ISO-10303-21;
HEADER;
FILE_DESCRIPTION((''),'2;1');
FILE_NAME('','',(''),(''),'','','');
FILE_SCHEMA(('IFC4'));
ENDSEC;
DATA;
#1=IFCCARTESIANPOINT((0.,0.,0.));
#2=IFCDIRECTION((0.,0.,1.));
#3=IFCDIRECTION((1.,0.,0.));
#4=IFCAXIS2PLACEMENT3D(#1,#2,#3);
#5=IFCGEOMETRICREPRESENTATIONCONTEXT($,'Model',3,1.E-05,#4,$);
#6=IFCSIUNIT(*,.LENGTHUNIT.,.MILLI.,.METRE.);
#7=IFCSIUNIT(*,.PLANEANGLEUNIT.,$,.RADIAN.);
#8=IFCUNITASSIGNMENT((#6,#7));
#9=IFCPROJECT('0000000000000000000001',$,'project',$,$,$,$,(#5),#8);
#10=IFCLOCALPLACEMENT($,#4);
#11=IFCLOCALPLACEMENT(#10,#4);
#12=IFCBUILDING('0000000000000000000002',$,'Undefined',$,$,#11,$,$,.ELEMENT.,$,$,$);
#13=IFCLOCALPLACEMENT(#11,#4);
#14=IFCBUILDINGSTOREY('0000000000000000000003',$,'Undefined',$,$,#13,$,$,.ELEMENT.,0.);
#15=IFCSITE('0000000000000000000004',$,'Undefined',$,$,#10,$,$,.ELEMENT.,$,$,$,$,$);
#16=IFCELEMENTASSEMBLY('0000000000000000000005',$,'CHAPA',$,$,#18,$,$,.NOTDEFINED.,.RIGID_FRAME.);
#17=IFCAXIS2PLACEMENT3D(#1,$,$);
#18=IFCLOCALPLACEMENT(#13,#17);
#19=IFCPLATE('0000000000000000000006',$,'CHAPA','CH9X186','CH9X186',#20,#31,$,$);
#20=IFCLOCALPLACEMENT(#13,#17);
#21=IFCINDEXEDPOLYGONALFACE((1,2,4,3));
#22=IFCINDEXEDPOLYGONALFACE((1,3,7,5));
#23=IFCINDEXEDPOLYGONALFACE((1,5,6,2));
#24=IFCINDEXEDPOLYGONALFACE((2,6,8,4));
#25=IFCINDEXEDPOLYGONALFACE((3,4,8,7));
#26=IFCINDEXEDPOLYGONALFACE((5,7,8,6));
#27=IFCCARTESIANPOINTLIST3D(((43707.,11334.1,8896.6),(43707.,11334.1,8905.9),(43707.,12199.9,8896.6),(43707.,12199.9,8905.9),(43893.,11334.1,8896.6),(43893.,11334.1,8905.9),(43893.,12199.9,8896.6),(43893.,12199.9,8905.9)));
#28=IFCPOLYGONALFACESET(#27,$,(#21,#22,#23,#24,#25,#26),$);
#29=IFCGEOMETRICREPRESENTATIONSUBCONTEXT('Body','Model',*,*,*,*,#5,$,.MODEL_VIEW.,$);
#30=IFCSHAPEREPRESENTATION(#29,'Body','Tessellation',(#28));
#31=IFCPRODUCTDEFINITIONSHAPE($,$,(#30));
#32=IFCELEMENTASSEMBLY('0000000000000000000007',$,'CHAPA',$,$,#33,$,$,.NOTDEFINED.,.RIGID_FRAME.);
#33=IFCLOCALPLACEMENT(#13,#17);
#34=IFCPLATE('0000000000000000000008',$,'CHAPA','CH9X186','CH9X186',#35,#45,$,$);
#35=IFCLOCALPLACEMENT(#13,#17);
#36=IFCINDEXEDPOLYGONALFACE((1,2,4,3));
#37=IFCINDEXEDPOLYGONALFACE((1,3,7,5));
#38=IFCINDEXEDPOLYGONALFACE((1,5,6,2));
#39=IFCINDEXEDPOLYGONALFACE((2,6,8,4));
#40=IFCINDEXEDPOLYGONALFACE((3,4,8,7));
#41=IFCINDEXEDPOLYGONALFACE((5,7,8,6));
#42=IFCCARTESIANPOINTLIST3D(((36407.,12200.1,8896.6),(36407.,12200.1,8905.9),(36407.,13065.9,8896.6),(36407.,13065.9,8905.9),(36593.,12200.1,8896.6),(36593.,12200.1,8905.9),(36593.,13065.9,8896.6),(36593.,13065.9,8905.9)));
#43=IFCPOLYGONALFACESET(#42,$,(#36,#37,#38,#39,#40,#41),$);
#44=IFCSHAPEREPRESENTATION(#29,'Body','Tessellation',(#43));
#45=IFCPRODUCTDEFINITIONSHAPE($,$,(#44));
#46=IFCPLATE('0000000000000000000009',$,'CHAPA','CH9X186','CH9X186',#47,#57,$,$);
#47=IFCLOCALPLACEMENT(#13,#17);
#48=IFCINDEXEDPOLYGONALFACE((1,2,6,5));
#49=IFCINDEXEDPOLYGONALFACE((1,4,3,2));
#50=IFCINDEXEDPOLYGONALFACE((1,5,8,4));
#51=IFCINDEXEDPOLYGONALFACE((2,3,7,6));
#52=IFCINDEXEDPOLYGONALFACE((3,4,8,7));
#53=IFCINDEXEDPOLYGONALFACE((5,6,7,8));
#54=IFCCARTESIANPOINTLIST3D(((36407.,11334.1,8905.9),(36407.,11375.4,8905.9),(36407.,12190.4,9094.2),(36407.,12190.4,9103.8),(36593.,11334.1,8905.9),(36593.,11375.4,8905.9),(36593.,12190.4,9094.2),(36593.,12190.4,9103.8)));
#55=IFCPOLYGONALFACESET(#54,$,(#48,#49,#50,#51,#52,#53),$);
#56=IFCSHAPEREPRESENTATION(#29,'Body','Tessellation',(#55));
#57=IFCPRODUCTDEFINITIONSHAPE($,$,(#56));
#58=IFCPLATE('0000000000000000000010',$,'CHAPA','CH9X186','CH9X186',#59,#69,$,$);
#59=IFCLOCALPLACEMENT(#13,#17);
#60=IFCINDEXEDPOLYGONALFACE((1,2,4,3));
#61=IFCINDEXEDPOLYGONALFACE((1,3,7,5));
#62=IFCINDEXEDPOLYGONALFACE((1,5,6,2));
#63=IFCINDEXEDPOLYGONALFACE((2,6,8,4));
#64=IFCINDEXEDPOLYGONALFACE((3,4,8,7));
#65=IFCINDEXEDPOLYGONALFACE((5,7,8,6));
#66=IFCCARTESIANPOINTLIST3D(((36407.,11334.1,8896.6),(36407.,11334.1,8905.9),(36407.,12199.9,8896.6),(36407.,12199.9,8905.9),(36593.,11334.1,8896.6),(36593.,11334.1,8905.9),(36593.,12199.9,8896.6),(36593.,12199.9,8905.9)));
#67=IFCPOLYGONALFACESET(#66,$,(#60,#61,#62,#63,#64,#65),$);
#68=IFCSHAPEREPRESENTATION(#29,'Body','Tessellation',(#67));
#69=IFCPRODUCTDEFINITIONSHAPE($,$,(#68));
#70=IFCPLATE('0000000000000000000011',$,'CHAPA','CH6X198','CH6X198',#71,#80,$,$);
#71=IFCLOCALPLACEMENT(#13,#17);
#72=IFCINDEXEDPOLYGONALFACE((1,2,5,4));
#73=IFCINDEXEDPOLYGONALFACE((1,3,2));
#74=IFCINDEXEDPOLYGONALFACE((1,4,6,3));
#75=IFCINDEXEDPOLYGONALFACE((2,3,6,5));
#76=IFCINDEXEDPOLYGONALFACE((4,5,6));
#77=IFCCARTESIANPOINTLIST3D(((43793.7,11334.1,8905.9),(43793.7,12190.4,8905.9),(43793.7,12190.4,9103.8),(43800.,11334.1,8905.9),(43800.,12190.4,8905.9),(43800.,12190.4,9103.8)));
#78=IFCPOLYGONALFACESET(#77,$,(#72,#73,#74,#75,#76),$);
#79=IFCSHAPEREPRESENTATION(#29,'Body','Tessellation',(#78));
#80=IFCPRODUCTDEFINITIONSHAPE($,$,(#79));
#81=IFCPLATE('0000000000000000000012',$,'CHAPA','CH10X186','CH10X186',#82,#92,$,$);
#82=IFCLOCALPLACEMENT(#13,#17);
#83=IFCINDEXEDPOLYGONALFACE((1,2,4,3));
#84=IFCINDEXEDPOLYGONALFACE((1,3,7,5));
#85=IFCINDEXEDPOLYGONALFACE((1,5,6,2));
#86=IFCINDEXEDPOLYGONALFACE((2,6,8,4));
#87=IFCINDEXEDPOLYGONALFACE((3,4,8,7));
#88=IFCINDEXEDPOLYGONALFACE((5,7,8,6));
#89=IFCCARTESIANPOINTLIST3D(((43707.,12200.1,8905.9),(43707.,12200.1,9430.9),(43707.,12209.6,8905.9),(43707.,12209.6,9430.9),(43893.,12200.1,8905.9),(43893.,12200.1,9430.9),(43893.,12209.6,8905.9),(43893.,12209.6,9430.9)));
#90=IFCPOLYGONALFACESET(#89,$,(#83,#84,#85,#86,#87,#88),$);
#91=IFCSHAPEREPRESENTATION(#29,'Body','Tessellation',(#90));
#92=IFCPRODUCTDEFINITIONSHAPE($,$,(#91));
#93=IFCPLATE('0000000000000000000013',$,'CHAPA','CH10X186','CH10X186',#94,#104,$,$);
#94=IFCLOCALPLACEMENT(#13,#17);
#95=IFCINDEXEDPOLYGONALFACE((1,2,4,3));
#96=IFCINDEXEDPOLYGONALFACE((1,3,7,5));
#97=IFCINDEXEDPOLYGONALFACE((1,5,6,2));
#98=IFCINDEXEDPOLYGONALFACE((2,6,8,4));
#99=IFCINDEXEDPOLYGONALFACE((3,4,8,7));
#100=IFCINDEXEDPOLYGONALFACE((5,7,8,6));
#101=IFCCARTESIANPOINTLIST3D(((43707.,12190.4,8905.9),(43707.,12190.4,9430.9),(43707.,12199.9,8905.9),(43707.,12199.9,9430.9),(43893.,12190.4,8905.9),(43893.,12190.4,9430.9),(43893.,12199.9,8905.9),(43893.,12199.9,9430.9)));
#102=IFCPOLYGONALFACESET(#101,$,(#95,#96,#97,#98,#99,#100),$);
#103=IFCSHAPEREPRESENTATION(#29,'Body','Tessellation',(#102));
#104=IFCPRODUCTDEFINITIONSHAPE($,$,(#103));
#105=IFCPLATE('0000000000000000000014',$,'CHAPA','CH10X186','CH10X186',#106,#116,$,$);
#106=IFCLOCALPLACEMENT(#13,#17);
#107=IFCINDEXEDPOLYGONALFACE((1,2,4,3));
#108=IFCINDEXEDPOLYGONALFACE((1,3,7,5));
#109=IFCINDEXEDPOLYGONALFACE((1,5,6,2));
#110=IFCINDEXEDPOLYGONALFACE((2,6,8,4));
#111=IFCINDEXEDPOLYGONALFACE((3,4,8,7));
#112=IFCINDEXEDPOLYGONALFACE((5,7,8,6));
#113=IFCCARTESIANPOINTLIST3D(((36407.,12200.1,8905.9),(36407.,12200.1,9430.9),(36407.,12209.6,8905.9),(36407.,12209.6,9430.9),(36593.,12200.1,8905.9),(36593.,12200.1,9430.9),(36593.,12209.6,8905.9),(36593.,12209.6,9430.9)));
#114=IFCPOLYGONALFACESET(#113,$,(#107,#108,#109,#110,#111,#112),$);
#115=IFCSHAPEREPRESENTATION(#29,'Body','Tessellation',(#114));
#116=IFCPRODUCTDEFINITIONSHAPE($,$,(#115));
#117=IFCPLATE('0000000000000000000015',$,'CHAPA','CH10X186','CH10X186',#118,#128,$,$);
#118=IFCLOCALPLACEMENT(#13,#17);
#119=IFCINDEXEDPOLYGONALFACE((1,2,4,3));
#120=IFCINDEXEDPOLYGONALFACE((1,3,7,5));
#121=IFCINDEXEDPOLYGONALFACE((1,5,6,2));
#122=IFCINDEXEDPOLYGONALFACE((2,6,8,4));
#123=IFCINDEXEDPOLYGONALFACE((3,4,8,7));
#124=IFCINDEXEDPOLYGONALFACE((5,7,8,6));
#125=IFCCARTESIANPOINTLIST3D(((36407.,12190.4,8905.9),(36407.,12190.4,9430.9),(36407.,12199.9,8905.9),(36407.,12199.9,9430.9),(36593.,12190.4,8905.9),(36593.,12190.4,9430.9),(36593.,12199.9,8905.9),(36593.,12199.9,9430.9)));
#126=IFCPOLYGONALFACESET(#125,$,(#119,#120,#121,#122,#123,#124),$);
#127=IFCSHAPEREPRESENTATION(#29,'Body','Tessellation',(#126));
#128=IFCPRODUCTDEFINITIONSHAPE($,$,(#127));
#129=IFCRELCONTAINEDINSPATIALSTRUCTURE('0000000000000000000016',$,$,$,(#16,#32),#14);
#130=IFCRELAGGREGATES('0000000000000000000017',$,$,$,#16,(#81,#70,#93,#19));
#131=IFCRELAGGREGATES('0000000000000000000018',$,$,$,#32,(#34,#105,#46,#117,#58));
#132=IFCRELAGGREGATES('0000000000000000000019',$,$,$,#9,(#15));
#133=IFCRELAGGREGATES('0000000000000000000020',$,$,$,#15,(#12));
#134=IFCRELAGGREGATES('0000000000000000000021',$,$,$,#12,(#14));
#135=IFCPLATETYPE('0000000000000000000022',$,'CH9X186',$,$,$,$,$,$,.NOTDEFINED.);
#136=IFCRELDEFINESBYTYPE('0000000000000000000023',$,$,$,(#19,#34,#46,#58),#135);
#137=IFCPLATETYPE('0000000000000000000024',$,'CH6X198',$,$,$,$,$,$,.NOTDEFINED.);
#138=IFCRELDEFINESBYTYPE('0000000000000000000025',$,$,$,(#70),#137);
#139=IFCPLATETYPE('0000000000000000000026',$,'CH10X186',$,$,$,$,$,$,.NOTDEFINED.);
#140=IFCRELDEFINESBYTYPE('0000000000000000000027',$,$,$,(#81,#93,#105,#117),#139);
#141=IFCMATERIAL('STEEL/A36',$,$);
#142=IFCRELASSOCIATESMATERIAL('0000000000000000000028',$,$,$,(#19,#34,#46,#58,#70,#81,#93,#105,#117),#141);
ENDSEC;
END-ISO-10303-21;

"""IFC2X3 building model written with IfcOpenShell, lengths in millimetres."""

from ifc_helpers import new_model, si_unit, frame, origin_with_axes, place, context, subcontext, project, spatial, polyline, outline, extrude, clip, halfspace, material, type_object, element, aggregate, save


model = new_model("IFC2X3")

# Units and contexts
model_context = context("Model", 3, precision=1e-05, world=origin_with_axes())
body_context = subcontext(model_context, "Body", "Model", "MODEL_VIEW")
ifc_project = project(units=[si_unit("LENGTHUNIT", "METRE", prefix="MILLI"), si_unit("PLANEANGLEUNIT", "RADIAN")], contexts=[model_context])

# Site, building, storey
site_placement = place(None, origin_with_axes())
site = spatial("IfcSite", under=ifc_project, at=site_placement, Name="Undefined", CompositionType="ELEMENT")
building_placement = place(site_placement, origin_with_axes())
building = spatial("IfcBuilding", under=site, at=building_placement, Name="Undefined", CompositionType="ELEMENT")
storey_placement = place(building_placement, origin_with_axes())
storey = spatial("IfcBuildingStorey", under=building, at=storey_placement, Name="Undefined", CompositionType="ELEMENT", Elevation=0.0)

# Shared definitions
ifc_material_1 = material(Name="STEEL/A36")

# Element assemblies, plates
assembly_1_placement = place(storey_placement, origin_with_axes())
assembly_1 = element("IfcElementAssembly", 1, at=assembly_1_placement, inside=storey, Name="CHAPA", AssemblyPlace="NOTDEFINED", PredefinedType="RIGID_FRAME")
plate_type_1 = type_object("IfcPlateType", Name="CH9X186", PredefinedType="NOTDEFINED")
plate_1_placement = place(assembly_1_placement, frame((43893.0, 12199.9, 8901.3), z_axis=(0.0, 0.0, 1.0), x_axis=(-1.0, 0.0, 0.0)))
plate_1 = element("IfcPlate", 2, at=plate_1_placement, type_object=plate_type_1, material=ifc_material_1, Name="CHAPA", Description="CH9X186", ObjectType="CH9X186", context=body_context, shape_type="SweptSolid", body=[
    extrude(outline(polyline([(0.0, 0.0), (186.0, 0.0), (186.0, 865.8), (0.0, 865.8), (0.0, 0.0)])), frame((0.0, 0.0, -4.7), z_axis=(0.0, 0.0, 1.0), x_axis=(1.0, 0.0, 0.0)), (0.0, 0.0, 1.0), 9.3),
])
assembly_2_placement = place(storey_placement, origin_with_axes())
assembly_2 = element("IfcElementAssembly", 3, at=assembly_2_placement, inside=storey, Name="CHAPA", AssemblyPlace="NOTDEFINED", PredefinedType="RIGID_FRAME")
plate_2_placement = place(assembly_2_placement, frame((36593.0, 12200.1, 8901.3), z_axis=(0.0, 0.0, -1.0), x_axis=(-1.0, 0.0, 0.0)))
plate_2 = element("IfcPlate", 4, at=plate_2_placement, type_object=plate_type_1, material=ifc_material_1, Name="CHAPA", Description="CH9X186", ObjectType="CH9X186", context=body_context, shape_type="SweptSolid", body=[
    extrude(outline(polyline([(0.0, 0.0), (186.0, 0.0), (186.0, 865.8), (0.0, 865.8), (0.0, 0.0)])), frame((0.0, 0.0, -4.7), z_axis=(0.0, 0.0, 1.0), x_axis=(1.0, 0.0, 0.0)), (0.0, 0.0, 1.0), 9.3),
])
plate_3_placement = place(assembly_2_placement, frame((36593.0, 12191.4, 9099.3), z_axis=(0.0, -0.225125, 0.97433), x_axis=(-1.0, 0.0, 0.0)))
plate_3 = element("IfcPlate", 5, at=plate_3_placement, type_object=plate_type_1, material=ifc_material_1, Name="CHAPA", Description="CH9X186", ObjectType="CH9X186", context=body_context, shape_type="Clipping", body=[
    clip(clip(extrude(outline(polyline([(0.0, 0.0), (186.0, 0.0), (186.0, 878.9), (0.0, 878.9), (0.0, 0.0)])), frame((0.0, 0.0, -4.7), z_axis=(0.0, 0.0, 1.0), x_axis=(1.0, 0.0, 0.0)), (0.0, 0.0, 1.0), 9.3), halfspace(frame((186.0, -500.0, -314.0), z_axis=(0.0, 0.225128, -0.974329), x_axis=(0.0, 0.974329, 0.225128)), False)), halfspace(frame((0.0, 2.1, -4.6), z_axis=(0.0, -0.97433, -0.225125), x_axis=(0.0, -0.225125, 0.97433)), False)),
])
plate_4_placement = place(assembly_2_placement, frame((36593.0, 12199.9, 8901.3), z_axis=(0.0, 0.0, 1.0), x_axis=(-1.0, 0.0, 0.0)))
plate_4 = element("IfcPlate", 6, at=plate_4_placement, type_object=plate_type_1, material=ifc_material_1, Name="CHAPA", Description="CH9X186", ObjectType="CH9X186", context=body_context, shape_type="SweptSolid", body=[
    extrude(outline(polyline([(0.0, 0.0), (186.0, 0.0), (186.0, 865.8), (0.0, 865.8), (0.0, 0.0)])), frame((0.0, 0.0, -4.7), z_axis=(0.0, 0.0, 1.0), x_axis=(1.0, 0.0, 0.0)), (0.0, 0.0, 1.0), 9.3),
])

# Plates
plate_type_2 = type_object("IfcPlateType", Name="CH6X198", PredefinedType="NOTDEFINED")
plate_5_placement = place(assembly_1_placement, frame((43796.8, 11334.1, 8905.9), z_axis=(1.0, 0.0, 0.0), x_axis=(0.0, 1.0, 0.0)))
plate_5 = element("IfcPlate", 7, at=plate_5_placement, type_object=plate_type_2, material=ifc_material_1, Name="CHAPA", Description="CH6X198", ObjectType="CH6X198", context=body_context, shape_type="SweptSolid", body=[
    extrude(outline(polyline([(0.0, 0.0), (856.3, 0.0), (856.3, 197.9), (0.0, 0.0)])), frame((0.0, 0.0, -3.1), z_axis=(0.0, 0.0, 1.0), x_axis=(1.0, 0.0, 0.0)), (0.0, 0.0, 1.0), 6.3),
])
plate_type_3 = type_object("IfcPlateType", Name="CH10X186", PredefinedType="NOTDEFINED")
plate_6_placement = place(assembly_1_placement, frame((43893.0, 12204.8, 9430.9), z_axis=(0.0, -1.0, 0.0), x_axis=(-1.0, 0.0, 0.0)))
plate_6 = element("IfcPlate", 8, at=plate_6_placement, type_object=plate_type_3, material=ifc_material_1, Name="CHAPA", Description="CH10X186", ObjectType="CH10X186", context=body_context, shape_type="SweptSolid", body=[
    extrude(outline(polyline([(0.0, 0.0), (186.0, 0.0), (186.0, 525.0), (0.0, 525.0), (0.0, 0.0)])), frame((0.0, 0.0, -4.8), z_axis=(0.0, 0.0, 1.0), x_axis=(1.0, 0.0, 0.0)), (0.0, 0.0, 1.0), 9.5),
])
plate_7_placement = place(assembly_1_placement, frame((43893.0, 12195.2, 9430.9), z_axis=(0.0, -1.0, 0.0), x_axis=(-1.0, 0.0, 0.0)))
plate_7 = element("IfcPlate", 9, at=plate_7_placement, type_object=plate_type_3, material=ifc_material_1, Name="CHAPA", Description="CH10X186", ObjectType="CH10X186", context=body_context, shape_type="SweptSolid", body=[
    extrude(outline(polyline([(0.0, 0.0), (186.0, 0.0), (186.0, 525.0), (0.0, 525.0), (0.0, 0.0)])), frame((0.0, 0.0, -4.8), z_axis=(0.0, 0.0, 1.0), x_axis=(1.0, 0.0, 0.0)), (0.0, 0.0, 1.0), 9.5),
])
aggregate(assembly_1, [plate_6, plate_5, plate_7, plate_1])
plate_8_placement = place(assembly_2_placement, frame((36593.0, 12204.8, 9430.9), z_axis=(0.0, -1.0, 0.0), x_axis=(-1.0, 0.0, 0.0)))
plate_8 = element("IfcPlate", 10, at=plate_8_placement, type_object=plate_type_3, material=ifc_material_1, Name="CHAPA", Description="CH10X186", ObjectType="CH10X186", context=body_context, shape_type="SweptSolid", body=[
    extrude(outline(polyline([(0.0, 0.0), (186.0, 0.0), (186.0, 525.0), (0.0, 525.0), (0.0, 0.0)])), frame((0.0, 0.0, -4.8), z_axis=(0.0, 0.0, 1.0), x_axis=(1.0, 0.0, 0.0)), (0.0, 0.0, 1.0), 9.5),
])
plate_9_placement = place(assembly_2_placement, frame((36593.0, 12195.2, 9430.9), z_axis=(0.0, -1.0, 0.0), x_axis=(-1.0, 0.0, 0.0)))
plate_9 = element("IfcPlate", 11, at=plate_9_placement, type_object=plate_type_3, material=ifc_material_1, Name="CHAPA", Description="CH10X186", ObjectType="CH10X186", context=body_context, shape_type="SweptSolid", body=[
    extrude(outline(polyline([(0.0, 0.0), (186.0, 0.0), (186.0, 525.0), (0.0, 525.0), (0.0, 0.0)])), frame((0.0, 0.0, -4.8), z_axis=(0.0, 0.0, 1.0), x_axis=(1.0, 0.0, 0.0)), (0.0, 0.0, 1.0), 9.5),
])
aggregate(assembly_2, [plate_2, plate_8, plate_3, plate_9, plate_4])

save(model, "model.ifc")
